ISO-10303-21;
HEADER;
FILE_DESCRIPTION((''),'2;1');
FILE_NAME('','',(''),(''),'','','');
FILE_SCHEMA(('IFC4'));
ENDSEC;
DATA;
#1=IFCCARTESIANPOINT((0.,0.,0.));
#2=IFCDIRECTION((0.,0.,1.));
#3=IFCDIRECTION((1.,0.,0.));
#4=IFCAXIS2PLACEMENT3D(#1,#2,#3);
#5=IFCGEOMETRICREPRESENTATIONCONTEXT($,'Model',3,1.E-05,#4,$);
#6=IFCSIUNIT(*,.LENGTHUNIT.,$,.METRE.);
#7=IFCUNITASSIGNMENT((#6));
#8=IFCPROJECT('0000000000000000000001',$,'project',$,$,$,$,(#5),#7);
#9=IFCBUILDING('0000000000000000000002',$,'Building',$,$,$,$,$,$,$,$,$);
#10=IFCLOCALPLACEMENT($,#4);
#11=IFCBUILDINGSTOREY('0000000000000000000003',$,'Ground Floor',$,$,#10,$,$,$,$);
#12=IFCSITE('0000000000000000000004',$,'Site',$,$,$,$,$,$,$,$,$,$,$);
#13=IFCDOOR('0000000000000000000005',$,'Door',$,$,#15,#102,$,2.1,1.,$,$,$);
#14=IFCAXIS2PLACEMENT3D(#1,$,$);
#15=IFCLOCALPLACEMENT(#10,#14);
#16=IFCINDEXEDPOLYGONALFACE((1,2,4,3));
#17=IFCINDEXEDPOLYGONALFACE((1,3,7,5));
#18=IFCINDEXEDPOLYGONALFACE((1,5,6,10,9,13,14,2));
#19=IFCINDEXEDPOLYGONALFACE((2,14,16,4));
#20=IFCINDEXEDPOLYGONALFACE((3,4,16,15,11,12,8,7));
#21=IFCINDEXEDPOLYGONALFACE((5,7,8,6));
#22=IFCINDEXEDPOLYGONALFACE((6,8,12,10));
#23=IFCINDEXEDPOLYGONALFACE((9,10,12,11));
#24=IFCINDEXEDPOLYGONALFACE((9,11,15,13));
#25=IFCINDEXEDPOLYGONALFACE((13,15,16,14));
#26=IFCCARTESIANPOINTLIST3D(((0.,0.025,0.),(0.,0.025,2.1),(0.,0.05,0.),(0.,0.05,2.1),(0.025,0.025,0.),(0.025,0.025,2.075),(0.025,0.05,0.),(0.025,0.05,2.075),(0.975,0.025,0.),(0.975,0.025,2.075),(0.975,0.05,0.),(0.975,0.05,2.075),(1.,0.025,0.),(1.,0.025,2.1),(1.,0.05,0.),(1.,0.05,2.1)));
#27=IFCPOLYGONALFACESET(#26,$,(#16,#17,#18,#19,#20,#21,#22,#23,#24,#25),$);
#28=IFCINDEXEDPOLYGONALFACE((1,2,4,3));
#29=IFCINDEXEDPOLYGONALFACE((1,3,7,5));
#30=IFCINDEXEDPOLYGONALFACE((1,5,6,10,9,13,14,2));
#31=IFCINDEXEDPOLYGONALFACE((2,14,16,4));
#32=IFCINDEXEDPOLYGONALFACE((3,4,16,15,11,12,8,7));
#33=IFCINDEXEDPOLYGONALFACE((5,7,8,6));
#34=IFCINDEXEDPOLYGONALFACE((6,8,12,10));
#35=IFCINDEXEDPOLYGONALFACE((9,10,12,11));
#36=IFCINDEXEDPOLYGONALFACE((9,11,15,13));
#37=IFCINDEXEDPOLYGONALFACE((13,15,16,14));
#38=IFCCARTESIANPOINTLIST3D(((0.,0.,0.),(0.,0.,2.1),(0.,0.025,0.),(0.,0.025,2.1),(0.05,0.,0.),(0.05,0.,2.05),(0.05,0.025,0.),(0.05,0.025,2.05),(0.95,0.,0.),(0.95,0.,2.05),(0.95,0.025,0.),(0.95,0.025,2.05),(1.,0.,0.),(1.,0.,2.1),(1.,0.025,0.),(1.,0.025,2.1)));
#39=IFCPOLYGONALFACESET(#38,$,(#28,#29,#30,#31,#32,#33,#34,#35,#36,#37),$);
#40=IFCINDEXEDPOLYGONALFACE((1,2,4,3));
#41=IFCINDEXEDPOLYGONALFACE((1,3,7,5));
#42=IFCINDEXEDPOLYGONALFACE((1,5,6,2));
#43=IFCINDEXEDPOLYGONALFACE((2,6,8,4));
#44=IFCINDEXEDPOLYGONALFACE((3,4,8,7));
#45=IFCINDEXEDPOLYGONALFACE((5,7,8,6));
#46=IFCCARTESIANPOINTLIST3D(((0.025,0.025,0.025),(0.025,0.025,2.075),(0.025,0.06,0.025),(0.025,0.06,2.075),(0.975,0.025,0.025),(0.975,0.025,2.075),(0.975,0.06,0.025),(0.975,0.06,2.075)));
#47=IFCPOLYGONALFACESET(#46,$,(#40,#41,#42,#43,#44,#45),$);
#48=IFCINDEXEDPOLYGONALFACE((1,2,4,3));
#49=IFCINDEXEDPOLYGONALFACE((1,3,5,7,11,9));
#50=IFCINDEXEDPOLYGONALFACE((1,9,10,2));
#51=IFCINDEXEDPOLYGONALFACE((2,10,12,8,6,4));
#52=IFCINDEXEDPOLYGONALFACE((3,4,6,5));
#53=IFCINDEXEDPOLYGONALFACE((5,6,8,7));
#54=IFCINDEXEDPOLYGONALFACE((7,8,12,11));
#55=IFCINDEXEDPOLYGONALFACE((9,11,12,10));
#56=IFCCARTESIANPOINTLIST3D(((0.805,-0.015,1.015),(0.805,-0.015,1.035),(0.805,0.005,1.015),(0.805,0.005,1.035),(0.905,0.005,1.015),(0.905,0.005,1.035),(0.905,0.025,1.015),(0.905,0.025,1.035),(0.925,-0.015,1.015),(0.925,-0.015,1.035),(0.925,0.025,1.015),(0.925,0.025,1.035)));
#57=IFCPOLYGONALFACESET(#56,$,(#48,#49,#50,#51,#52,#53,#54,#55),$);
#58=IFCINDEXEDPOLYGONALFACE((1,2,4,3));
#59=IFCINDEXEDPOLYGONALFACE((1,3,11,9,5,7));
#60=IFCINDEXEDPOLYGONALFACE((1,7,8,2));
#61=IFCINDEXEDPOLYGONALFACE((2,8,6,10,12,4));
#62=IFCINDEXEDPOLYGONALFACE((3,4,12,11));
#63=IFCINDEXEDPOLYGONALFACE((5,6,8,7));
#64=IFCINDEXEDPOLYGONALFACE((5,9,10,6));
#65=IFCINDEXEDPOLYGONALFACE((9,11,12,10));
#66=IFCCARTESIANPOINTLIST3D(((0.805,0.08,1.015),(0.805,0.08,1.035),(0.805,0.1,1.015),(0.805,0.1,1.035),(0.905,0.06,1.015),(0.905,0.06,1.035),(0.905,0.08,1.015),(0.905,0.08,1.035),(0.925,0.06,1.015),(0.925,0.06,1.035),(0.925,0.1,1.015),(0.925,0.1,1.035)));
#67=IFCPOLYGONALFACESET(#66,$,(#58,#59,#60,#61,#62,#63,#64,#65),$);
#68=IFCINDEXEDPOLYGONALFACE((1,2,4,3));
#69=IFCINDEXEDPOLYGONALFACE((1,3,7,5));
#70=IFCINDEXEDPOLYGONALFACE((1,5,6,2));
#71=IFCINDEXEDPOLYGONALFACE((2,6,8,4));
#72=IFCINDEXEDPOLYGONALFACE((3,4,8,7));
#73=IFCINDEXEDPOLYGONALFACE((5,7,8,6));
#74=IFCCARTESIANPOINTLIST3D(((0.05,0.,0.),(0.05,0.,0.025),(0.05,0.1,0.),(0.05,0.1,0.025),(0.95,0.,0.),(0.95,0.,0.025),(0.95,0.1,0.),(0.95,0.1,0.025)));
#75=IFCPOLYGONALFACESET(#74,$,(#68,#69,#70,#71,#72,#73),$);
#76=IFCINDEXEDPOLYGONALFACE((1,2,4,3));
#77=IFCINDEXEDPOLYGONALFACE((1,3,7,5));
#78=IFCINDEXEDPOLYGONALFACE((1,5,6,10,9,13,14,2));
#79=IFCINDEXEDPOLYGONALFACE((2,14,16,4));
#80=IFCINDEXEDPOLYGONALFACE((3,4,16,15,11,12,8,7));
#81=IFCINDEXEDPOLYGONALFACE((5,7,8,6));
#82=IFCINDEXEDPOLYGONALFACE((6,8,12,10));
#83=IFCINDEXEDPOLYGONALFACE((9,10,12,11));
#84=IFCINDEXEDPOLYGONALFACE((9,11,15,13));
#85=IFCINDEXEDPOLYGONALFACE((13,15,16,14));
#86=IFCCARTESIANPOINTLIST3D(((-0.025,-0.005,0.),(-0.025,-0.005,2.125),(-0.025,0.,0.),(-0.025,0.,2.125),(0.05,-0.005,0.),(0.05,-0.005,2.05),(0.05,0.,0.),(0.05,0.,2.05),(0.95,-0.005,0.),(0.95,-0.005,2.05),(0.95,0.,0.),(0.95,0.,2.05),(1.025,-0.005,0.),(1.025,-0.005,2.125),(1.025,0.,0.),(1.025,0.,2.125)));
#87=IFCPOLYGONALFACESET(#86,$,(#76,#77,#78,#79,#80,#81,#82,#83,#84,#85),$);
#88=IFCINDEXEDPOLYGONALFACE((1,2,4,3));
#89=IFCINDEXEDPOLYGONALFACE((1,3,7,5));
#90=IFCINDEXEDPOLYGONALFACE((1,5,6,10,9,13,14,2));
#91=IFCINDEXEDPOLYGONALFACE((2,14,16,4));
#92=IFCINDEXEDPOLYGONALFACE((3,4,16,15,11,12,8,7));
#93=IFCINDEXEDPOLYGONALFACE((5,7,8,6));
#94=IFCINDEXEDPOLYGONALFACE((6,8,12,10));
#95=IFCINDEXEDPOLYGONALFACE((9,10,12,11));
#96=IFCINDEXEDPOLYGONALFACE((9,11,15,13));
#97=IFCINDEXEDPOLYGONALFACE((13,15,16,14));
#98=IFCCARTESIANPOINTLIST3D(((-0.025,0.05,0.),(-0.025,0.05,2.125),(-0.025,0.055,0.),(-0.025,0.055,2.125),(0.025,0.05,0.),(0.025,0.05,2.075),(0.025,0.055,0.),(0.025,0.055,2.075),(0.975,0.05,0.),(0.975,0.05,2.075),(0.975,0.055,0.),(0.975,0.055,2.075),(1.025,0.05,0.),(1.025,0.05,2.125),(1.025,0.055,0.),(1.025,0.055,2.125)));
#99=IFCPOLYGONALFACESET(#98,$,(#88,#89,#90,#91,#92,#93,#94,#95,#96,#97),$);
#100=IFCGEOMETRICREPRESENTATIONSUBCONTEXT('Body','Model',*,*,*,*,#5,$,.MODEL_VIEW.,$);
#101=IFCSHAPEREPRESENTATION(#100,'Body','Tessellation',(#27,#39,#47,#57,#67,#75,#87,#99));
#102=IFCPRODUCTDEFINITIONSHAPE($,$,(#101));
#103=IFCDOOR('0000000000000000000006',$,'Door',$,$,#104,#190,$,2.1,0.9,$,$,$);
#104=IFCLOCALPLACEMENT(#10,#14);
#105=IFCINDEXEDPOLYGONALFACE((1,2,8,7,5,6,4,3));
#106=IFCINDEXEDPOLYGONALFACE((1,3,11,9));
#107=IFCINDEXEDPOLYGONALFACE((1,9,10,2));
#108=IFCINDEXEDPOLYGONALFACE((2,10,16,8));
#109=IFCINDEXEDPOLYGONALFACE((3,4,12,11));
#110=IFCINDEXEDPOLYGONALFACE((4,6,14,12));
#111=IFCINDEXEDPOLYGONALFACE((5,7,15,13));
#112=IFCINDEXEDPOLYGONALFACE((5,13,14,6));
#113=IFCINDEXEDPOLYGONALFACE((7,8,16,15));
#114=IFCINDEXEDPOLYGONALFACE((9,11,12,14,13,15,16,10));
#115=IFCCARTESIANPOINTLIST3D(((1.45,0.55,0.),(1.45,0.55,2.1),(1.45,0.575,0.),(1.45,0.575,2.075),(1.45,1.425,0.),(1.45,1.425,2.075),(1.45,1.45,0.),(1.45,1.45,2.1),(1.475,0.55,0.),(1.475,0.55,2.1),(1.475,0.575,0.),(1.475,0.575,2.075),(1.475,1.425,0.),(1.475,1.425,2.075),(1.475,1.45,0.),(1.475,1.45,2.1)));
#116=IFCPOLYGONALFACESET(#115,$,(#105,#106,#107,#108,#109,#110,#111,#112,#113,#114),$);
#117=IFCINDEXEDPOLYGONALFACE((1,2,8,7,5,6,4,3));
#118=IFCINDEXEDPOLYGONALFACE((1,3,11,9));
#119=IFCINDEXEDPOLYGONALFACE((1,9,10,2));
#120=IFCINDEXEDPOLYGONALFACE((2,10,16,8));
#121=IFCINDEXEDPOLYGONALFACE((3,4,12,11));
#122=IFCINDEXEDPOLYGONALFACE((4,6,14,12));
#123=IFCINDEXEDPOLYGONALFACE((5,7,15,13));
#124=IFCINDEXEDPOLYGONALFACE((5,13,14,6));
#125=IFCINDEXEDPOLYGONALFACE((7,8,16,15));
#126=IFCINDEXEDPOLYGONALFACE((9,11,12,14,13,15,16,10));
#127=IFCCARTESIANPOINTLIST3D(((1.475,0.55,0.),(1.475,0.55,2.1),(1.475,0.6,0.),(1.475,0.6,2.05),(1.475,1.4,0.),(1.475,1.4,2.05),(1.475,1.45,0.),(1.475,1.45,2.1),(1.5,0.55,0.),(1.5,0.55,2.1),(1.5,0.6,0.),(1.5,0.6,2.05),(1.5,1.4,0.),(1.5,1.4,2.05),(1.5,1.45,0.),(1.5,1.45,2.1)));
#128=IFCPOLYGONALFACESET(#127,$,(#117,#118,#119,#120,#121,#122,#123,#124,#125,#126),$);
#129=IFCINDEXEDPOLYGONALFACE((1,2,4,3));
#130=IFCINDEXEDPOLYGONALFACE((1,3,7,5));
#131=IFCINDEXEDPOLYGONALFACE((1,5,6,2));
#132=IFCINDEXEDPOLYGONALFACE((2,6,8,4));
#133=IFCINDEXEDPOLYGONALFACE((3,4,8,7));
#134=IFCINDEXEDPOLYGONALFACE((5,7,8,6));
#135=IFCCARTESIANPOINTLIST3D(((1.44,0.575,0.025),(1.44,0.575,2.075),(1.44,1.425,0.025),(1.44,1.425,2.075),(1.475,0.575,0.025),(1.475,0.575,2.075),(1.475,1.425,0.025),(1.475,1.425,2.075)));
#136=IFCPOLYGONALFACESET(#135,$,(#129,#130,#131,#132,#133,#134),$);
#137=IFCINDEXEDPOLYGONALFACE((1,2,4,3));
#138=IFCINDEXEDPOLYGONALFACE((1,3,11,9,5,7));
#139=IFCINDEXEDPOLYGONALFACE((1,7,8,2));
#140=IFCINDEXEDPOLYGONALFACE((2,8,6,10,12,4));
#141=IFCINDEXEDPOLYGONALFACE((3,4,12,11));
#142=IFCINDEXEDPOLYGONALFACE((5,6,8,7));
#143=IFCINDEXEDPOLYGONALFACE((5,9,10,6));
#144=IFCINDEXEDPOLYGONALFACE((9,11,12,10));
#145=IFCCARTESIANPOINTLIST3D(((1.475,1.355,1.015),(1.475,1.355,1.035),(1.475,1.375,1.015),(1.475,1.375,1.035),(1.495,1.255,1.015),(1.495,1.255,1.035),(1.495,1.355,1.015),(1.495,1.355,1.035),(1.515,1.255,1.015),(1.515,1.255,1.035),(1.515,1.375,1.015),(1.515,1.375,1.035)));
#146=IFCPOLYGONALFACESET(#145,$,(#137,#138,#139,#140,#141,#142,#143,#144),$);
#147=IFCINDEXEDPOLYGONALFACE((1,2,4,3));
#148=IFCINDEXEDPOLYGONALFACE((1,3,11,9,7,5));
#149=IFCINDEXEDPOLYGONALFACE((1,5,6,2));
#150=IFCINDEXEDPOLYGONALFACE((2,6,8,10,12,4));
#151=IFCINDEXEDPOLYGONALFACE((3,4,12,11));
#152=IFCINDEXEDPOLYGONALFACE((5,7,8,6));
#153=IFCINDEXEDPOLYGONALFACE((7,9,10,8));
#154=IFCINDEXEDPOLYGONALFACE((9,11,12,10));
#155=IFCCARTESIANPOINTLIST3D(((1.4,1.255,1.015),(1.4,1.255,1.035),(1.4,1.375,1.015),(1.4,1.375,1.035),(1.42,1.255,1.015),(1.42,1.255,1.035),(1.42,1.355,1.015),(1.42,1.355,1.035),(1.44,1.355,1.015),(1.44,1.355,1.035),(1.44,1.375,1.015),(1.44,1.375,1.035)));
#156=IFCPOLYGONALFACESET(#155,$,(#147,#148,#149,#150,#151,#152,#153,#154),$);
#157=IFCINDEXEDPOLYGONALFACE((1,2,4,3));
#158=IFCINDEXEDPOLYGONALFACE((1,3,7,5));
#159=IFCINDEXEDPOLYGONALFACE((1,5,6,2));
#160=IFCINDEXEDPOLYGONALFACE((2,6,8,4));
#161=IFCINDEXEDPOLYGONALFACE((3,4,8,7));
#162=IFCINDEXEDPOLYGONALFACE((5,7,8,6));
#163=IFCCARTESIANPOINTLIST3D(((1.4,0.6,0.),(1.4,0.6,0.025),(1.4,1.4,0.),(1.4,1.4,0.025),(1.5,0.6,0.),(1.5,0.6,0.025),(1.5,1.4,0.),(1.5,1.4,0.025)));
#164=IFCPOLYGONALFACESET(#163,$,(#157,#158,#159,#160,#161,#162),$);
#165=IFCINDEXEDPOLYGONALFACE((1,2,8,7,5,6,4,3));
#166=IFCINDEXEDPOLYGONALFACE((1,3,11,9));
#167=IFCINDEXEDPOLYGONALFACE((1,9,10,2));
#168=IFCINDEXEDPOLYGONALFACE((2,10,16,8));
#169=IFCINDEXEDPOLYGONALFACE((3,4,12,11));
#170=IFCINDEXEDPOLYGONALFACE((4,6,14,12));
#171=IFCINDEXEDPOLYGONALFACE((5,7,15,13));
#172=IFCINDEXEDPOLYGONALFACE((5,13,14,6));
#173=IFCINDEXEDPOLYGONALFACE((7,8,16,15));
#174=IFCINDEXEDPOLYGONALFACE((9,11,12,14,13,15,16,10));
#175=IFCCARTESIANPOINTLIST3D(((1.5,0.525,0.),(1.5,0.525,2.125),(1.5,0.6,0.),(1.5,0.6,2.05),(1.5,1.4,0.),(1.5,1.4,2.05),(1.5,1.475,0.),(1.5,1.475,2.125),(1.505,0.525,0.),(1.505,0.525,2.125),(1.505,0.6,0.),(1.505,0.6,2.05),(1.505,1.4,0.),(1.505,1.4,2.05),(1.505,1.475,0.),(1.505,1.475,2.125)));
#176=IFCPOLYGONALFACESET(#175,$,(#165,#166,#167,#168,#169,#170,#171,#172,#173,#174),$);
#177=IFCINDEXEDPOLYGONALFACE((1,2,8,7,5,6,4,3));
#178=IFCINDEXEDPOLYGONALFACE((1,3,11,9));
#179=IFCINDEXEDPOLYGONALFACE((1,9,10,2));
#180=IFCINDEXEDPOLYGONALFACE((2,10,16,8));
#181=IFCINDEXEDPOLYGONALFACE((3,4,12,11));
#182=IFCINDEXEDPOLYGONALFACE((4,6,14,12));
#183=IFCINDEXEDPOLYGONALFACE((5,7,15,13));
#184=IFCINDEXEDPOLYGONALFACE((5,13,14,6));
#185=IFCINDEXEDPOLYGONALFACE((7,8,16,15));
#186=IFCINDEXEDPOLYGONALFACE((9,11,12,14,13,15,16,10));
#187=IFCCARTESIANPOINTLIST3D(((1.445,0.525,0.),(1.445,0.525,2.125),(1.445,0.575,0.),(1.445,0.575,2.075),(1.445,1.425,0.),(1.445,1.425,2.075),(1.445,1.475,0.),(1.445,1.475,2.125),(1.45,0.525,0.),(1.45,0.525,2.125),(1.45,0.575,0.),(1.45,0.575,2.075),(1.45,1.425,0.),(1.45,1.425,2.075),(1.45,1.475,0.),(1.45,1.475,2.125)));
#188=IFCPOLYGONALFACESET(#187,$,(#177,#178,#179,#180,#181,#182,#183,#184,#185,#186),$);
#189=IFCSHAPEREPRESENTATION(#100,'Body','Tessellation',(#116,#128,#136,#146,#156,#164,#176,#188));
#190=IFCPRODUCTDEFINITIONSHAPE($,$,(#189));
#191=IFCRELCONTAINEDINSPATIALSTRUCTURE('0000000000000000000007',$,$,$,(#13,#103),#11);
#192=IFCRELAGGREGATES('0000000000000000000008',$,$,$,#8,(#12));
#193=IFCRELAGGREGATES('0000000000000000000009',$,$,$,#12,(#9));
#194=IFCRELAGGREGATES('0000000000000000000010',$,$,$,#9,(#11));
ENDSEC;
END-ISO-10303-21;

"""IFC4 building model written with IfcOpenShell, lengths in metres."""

from ifc_helpers import new_model, si_unit, frame, origin_with_axes, place, context, subcontext, project, spatial, line, indexed_curve, outline, extrude, element, save


model = new_model("IFC4")

# Units and contexts
model_context = context("Model", 3, precision=1e-05, world=origin_with_axes())
body_context = subcontext(model_context, "Body", "Model", "MODEL_VIEW")
ifc_project = project(units=[si_unit("LENGTHUNIT", "METRE")], contexts=[model_context])

# Site, building, storey
site = spatial("IfcSite", under=ifc_project, Name="Site")
building = spatial("IfcBuilding", under=site, Name="Building")
storey_placement = place(None, origin_with_axes())
storey = spatial("IfcBuildingStorey", under=building, at=storey_placement, Name="Ground Floor")

# Doors
door_1_placement = place(storey_placement, origin_with_axes())
element("IfcDoor", 1, at=door_1_placement, inside=storey, Name="Door", OverallHeight=2.1, OverallWidth=1.0, context=body_context, shape_type="SweptSolid", body=[
    extrude(outline(indexed_curve([(0.0, 0.0), (0.0, 2.1), (1.0, 2.1), (1.0, 0.0), (0.975, 0.0), (0.975, 2.075), (0.025, 2.075), (0.025, 0.0)], segments=[line(1, 2, 3, 4, 5, 6, 7, 8, 1)])), frame((0.0, 0.025, 0.0), z_axis=(0.0, -1.0, 0.0), x_axis=(1.0, 0.0, 0.0)), (0.0, 0.0, -1.0), 0.025),
    extrude(outline(indexed_curve([(0.0, 0.0), (0.0, 2.1), (1.0, 2.1), (1.0, 0.0), (0.95, 0.0), (0.95, 2.05), (0.05, 2.05), (0.05, 0.0)], segments=[line(1, 2, 3, 4, 5, 6, 7, 8, 1)])), frame((0.0, 0.0, 0.0), z_axis=(0.0, -1.0, 0.0), x_axis=(1.0, 0.0, 0.0)), (0.0, 0.0, -1.0), 0.025),
    extrude(outline(indexed_curve([(0.0, 0.0), (0.95, 0.0), (0.95, 0.035), (0.0, 0.035)], segments=[line(1, 2, 3, 4, 1)])), frame((0.025, 0.025, 0.025), z_axis=(0.0, 0.0, 1.0), x_axis=(1.0, 0.0, 0.0)), (0.0, 0.0, 1.0), 2.05),
    extrude(outline(indexed_curve([(0.0, 0.0), (0.0, -0.04), (-0.12, -0.04), (-0.12, -0.02), (-0.02, -0.02), (-0.02, 0.0)], segments=[line(1, 2, 3, 4, 5, 6, 1)])), frame((0.925, 0.025, 1.015), z_axis=(0.0, 0.0, 1.0), x_axis=(1.0, 0.0, 0.0)), (0.0, 0.0, 1.0), 0.02),
    extrude(outline(indexed_curve([(0.0, 0.0), (0.0, 0.04), (-0.12, 0.04), (-0.12, 0.02), (-0.02, 0.02), (-0.02, 0.0)], segments=[line(1, 2, 3, 4, 5, 6, 1)])), frame((0.925, 0.06, 1.015), z_axis=(0.0, 0.0, 1.0), x_axis=(1.0, 0.0, 0.0)), (0.0, 0.0, 1.0), 0.02),
    extrude(outline(indexed_curve([(0.0, 0.0), (0.9, 0.0), (0.9, 0.1), (0.0, 0.1)], segments=[line(1, 2, 3, 4, 1)])), frame((0.05, 0.0, 0.0), z_axis=(0.0, 0.0, 1.0), x_axis=(1.0, 0.0, 0.0)), (0.0, 0.0, 1.0), 0.025),
    extrude(outline(indexed_curve([(0.0, 0.0), (0.0, 2.125), (1.05, 2.125), (1.05, 0.0), (0.975, 0.0), (0.975, 2.05), (0.075, 2.05), (0.075, 0.0)], segments=[line(1, 2, 3, 4, 5, 6, 7, 8, 1)])), frame((-0.025, -0.005, 0.0), z_axis=(0.0, -1.0, 0.0), x_axis=(1.0, 0.0, 0.0)), (0.0, 0.0, -1.0), 0.005),
    extrude(outline(indexed_curve([(0.0, 0.0), (0.0, 2.125), (1.05, 2.125), (1.05, 0.0), (1.0, 0.0), (1.0, 2.075), (0.05, 2.075), (0.05, 0.0)], segments=[line(1, 2, 3, 4, 5, 6, 7, 8, 1)])), frame((-0.025, 0.05, 0.0), z_axis=(0.0, -1.0, 0.0), x_axis=(1.0, 0.0, 0.0)), (0.0, 0.0, -1.0), 0.005),
])
door_2_placement = place(storey_placement, frame((1.5, 0.55, 0.0), z_axis=(0.0, 0.0, 1.0), x_axis=(0.0, 1.0, 0.0)))
element("IfcDoor", 2, at=door_2_placement, inside=storey, Name="Door", OverallHeight=2.1, OverallWidth=0.9, context=body_context, shape_type="SweptSolid", body=[
    extrude(outline(indexed_curve([(0.0, 0.0), (0.0, 2.1), (0.9, 2.1), (0.9, 0.0), (0.875, 0.0), (0.875, 2.075), (0.025, 2.075), (0.025, 0.0)], segments=[line(1, 2, 3, 4, 5, 6, 7, 8, 1)])), frame((0.0, 0.025, 0.0), z_axis=(0.0, -1.0, 0.0), x_axis=(1.0, 0.0, 0.0)), (0.0, 0.0, -1.0), 0.025),
    extrude(outline(indexed_curve([(0.0, 0.0), (0.0, 2.1), (0.9, 2.1), (0.9, 0.0), (0.85, 0.0), (0.85, 2.05), (0.05, 2.05), (0.05, 0.0)], segments=[line(1, 2, 3, 4, 5, 6, 7, 8, 1)])), frame((0.0, 0.0, 0.0), z_axis=(0.0, -1.0, 0.0), x_axis=(1.0, 0.0, 0.0)), (0.0, 0.0, -1.0), 0.025),
    extrude(outline(indexed_curve([(0.0, 0.0), (0.85, 0.0), (0.85, 0.035), (0.0, 0.035)], segments=[line(1, 2, 3, 4, 1)])), frame((0.025, 0.025, 0.025), z_axis=(0.0, 0.0, 1.0), x_axis=(1.0, 0.0, 0.0)), (0.0, 0.0, 1.0), 2.05),
    extrude(outline(indexed_curve([(0.0, 0.0), (0.0, -0.04), (-0.12, -0.04), (-0.12, -0.02), (-0.02, -0.02), (-0.02, 0.0)], segments=[line(1, 2, 3, 4, 5, 6, 1)])), frame((0.825, 0.025, 1.015), z_axis=(0.0, 0.0, 1.0), x_axis=(1.0, 0.0, 0.0)), (0.0, 0.0, 1.0), 0.02),
    extrude(outline(indexed_curve([(0.0, 0.0), (0.0, 0.04), (-0.12, 0.04), (-0.12, 0.02), (-0.02, 0.02), (-0.02, 0.0)], segments=[line(1, 2, 3, 4, 5, 6, 1)])), frame((0.825, 0.06, 1.015), z_axis=(0.0, 0.0, 1.0), x_axis=(1.0, 0.0, 0.0)), (0.0, 0.0, 1.0), 0.02),
    extrude(outline(indexed_curve([(0.0, 0.0), (0.8, 0.0), (0.8, 0.1), (0.0, 0.1)], segments=[line(1, 2, 3, 4, 1)])), frame((0.05, 0.0, 0.0), z_axis=(0.0, 0.0, 1.0), x_axis=(1.0, 0.0, 0.0)), (0.0, 0.0, 1.0), 0.025),
    extrude(outline(indexed_curve([(0.0, 0.0), (0.0, 2.125), (0.95, 2.125), (0.95, 0.0), (0.875, 0.0), (0.875, 2.05), (0.075, 2.05), (0.075, 0.0)], segments=[line(1, 2, 3, 4, 5, 6, 7, 8, 1)])), frame((-0.025, -0.005, 0.0), z_axis=(0.0, -1.0, 0.0), x_axis=(1.0, 0.0, 0.0)), (0.0, 0.0, -1.0), 0.005),
    extrude(outline(indexed_curve([(0.0, 0.0), (0.0, 2.125), (0.95, 2.125), (0.95, 0.0), (0.9, 0.0), (0.9, 2.075), (0.05, 2.075), (0.05, 0.0)], segments=[line(1, 2, 3, 4, 5, 6, 7, 8, 1)])), frame((-0.025, 0.05, 0.0), z_axis=(0.0, -1.0, 0.0), x_axis=(1.0, 0.0, 0.0)), (0.0, 0.0, -1.0), 0.005),
])

save(model, "model.ifc")
